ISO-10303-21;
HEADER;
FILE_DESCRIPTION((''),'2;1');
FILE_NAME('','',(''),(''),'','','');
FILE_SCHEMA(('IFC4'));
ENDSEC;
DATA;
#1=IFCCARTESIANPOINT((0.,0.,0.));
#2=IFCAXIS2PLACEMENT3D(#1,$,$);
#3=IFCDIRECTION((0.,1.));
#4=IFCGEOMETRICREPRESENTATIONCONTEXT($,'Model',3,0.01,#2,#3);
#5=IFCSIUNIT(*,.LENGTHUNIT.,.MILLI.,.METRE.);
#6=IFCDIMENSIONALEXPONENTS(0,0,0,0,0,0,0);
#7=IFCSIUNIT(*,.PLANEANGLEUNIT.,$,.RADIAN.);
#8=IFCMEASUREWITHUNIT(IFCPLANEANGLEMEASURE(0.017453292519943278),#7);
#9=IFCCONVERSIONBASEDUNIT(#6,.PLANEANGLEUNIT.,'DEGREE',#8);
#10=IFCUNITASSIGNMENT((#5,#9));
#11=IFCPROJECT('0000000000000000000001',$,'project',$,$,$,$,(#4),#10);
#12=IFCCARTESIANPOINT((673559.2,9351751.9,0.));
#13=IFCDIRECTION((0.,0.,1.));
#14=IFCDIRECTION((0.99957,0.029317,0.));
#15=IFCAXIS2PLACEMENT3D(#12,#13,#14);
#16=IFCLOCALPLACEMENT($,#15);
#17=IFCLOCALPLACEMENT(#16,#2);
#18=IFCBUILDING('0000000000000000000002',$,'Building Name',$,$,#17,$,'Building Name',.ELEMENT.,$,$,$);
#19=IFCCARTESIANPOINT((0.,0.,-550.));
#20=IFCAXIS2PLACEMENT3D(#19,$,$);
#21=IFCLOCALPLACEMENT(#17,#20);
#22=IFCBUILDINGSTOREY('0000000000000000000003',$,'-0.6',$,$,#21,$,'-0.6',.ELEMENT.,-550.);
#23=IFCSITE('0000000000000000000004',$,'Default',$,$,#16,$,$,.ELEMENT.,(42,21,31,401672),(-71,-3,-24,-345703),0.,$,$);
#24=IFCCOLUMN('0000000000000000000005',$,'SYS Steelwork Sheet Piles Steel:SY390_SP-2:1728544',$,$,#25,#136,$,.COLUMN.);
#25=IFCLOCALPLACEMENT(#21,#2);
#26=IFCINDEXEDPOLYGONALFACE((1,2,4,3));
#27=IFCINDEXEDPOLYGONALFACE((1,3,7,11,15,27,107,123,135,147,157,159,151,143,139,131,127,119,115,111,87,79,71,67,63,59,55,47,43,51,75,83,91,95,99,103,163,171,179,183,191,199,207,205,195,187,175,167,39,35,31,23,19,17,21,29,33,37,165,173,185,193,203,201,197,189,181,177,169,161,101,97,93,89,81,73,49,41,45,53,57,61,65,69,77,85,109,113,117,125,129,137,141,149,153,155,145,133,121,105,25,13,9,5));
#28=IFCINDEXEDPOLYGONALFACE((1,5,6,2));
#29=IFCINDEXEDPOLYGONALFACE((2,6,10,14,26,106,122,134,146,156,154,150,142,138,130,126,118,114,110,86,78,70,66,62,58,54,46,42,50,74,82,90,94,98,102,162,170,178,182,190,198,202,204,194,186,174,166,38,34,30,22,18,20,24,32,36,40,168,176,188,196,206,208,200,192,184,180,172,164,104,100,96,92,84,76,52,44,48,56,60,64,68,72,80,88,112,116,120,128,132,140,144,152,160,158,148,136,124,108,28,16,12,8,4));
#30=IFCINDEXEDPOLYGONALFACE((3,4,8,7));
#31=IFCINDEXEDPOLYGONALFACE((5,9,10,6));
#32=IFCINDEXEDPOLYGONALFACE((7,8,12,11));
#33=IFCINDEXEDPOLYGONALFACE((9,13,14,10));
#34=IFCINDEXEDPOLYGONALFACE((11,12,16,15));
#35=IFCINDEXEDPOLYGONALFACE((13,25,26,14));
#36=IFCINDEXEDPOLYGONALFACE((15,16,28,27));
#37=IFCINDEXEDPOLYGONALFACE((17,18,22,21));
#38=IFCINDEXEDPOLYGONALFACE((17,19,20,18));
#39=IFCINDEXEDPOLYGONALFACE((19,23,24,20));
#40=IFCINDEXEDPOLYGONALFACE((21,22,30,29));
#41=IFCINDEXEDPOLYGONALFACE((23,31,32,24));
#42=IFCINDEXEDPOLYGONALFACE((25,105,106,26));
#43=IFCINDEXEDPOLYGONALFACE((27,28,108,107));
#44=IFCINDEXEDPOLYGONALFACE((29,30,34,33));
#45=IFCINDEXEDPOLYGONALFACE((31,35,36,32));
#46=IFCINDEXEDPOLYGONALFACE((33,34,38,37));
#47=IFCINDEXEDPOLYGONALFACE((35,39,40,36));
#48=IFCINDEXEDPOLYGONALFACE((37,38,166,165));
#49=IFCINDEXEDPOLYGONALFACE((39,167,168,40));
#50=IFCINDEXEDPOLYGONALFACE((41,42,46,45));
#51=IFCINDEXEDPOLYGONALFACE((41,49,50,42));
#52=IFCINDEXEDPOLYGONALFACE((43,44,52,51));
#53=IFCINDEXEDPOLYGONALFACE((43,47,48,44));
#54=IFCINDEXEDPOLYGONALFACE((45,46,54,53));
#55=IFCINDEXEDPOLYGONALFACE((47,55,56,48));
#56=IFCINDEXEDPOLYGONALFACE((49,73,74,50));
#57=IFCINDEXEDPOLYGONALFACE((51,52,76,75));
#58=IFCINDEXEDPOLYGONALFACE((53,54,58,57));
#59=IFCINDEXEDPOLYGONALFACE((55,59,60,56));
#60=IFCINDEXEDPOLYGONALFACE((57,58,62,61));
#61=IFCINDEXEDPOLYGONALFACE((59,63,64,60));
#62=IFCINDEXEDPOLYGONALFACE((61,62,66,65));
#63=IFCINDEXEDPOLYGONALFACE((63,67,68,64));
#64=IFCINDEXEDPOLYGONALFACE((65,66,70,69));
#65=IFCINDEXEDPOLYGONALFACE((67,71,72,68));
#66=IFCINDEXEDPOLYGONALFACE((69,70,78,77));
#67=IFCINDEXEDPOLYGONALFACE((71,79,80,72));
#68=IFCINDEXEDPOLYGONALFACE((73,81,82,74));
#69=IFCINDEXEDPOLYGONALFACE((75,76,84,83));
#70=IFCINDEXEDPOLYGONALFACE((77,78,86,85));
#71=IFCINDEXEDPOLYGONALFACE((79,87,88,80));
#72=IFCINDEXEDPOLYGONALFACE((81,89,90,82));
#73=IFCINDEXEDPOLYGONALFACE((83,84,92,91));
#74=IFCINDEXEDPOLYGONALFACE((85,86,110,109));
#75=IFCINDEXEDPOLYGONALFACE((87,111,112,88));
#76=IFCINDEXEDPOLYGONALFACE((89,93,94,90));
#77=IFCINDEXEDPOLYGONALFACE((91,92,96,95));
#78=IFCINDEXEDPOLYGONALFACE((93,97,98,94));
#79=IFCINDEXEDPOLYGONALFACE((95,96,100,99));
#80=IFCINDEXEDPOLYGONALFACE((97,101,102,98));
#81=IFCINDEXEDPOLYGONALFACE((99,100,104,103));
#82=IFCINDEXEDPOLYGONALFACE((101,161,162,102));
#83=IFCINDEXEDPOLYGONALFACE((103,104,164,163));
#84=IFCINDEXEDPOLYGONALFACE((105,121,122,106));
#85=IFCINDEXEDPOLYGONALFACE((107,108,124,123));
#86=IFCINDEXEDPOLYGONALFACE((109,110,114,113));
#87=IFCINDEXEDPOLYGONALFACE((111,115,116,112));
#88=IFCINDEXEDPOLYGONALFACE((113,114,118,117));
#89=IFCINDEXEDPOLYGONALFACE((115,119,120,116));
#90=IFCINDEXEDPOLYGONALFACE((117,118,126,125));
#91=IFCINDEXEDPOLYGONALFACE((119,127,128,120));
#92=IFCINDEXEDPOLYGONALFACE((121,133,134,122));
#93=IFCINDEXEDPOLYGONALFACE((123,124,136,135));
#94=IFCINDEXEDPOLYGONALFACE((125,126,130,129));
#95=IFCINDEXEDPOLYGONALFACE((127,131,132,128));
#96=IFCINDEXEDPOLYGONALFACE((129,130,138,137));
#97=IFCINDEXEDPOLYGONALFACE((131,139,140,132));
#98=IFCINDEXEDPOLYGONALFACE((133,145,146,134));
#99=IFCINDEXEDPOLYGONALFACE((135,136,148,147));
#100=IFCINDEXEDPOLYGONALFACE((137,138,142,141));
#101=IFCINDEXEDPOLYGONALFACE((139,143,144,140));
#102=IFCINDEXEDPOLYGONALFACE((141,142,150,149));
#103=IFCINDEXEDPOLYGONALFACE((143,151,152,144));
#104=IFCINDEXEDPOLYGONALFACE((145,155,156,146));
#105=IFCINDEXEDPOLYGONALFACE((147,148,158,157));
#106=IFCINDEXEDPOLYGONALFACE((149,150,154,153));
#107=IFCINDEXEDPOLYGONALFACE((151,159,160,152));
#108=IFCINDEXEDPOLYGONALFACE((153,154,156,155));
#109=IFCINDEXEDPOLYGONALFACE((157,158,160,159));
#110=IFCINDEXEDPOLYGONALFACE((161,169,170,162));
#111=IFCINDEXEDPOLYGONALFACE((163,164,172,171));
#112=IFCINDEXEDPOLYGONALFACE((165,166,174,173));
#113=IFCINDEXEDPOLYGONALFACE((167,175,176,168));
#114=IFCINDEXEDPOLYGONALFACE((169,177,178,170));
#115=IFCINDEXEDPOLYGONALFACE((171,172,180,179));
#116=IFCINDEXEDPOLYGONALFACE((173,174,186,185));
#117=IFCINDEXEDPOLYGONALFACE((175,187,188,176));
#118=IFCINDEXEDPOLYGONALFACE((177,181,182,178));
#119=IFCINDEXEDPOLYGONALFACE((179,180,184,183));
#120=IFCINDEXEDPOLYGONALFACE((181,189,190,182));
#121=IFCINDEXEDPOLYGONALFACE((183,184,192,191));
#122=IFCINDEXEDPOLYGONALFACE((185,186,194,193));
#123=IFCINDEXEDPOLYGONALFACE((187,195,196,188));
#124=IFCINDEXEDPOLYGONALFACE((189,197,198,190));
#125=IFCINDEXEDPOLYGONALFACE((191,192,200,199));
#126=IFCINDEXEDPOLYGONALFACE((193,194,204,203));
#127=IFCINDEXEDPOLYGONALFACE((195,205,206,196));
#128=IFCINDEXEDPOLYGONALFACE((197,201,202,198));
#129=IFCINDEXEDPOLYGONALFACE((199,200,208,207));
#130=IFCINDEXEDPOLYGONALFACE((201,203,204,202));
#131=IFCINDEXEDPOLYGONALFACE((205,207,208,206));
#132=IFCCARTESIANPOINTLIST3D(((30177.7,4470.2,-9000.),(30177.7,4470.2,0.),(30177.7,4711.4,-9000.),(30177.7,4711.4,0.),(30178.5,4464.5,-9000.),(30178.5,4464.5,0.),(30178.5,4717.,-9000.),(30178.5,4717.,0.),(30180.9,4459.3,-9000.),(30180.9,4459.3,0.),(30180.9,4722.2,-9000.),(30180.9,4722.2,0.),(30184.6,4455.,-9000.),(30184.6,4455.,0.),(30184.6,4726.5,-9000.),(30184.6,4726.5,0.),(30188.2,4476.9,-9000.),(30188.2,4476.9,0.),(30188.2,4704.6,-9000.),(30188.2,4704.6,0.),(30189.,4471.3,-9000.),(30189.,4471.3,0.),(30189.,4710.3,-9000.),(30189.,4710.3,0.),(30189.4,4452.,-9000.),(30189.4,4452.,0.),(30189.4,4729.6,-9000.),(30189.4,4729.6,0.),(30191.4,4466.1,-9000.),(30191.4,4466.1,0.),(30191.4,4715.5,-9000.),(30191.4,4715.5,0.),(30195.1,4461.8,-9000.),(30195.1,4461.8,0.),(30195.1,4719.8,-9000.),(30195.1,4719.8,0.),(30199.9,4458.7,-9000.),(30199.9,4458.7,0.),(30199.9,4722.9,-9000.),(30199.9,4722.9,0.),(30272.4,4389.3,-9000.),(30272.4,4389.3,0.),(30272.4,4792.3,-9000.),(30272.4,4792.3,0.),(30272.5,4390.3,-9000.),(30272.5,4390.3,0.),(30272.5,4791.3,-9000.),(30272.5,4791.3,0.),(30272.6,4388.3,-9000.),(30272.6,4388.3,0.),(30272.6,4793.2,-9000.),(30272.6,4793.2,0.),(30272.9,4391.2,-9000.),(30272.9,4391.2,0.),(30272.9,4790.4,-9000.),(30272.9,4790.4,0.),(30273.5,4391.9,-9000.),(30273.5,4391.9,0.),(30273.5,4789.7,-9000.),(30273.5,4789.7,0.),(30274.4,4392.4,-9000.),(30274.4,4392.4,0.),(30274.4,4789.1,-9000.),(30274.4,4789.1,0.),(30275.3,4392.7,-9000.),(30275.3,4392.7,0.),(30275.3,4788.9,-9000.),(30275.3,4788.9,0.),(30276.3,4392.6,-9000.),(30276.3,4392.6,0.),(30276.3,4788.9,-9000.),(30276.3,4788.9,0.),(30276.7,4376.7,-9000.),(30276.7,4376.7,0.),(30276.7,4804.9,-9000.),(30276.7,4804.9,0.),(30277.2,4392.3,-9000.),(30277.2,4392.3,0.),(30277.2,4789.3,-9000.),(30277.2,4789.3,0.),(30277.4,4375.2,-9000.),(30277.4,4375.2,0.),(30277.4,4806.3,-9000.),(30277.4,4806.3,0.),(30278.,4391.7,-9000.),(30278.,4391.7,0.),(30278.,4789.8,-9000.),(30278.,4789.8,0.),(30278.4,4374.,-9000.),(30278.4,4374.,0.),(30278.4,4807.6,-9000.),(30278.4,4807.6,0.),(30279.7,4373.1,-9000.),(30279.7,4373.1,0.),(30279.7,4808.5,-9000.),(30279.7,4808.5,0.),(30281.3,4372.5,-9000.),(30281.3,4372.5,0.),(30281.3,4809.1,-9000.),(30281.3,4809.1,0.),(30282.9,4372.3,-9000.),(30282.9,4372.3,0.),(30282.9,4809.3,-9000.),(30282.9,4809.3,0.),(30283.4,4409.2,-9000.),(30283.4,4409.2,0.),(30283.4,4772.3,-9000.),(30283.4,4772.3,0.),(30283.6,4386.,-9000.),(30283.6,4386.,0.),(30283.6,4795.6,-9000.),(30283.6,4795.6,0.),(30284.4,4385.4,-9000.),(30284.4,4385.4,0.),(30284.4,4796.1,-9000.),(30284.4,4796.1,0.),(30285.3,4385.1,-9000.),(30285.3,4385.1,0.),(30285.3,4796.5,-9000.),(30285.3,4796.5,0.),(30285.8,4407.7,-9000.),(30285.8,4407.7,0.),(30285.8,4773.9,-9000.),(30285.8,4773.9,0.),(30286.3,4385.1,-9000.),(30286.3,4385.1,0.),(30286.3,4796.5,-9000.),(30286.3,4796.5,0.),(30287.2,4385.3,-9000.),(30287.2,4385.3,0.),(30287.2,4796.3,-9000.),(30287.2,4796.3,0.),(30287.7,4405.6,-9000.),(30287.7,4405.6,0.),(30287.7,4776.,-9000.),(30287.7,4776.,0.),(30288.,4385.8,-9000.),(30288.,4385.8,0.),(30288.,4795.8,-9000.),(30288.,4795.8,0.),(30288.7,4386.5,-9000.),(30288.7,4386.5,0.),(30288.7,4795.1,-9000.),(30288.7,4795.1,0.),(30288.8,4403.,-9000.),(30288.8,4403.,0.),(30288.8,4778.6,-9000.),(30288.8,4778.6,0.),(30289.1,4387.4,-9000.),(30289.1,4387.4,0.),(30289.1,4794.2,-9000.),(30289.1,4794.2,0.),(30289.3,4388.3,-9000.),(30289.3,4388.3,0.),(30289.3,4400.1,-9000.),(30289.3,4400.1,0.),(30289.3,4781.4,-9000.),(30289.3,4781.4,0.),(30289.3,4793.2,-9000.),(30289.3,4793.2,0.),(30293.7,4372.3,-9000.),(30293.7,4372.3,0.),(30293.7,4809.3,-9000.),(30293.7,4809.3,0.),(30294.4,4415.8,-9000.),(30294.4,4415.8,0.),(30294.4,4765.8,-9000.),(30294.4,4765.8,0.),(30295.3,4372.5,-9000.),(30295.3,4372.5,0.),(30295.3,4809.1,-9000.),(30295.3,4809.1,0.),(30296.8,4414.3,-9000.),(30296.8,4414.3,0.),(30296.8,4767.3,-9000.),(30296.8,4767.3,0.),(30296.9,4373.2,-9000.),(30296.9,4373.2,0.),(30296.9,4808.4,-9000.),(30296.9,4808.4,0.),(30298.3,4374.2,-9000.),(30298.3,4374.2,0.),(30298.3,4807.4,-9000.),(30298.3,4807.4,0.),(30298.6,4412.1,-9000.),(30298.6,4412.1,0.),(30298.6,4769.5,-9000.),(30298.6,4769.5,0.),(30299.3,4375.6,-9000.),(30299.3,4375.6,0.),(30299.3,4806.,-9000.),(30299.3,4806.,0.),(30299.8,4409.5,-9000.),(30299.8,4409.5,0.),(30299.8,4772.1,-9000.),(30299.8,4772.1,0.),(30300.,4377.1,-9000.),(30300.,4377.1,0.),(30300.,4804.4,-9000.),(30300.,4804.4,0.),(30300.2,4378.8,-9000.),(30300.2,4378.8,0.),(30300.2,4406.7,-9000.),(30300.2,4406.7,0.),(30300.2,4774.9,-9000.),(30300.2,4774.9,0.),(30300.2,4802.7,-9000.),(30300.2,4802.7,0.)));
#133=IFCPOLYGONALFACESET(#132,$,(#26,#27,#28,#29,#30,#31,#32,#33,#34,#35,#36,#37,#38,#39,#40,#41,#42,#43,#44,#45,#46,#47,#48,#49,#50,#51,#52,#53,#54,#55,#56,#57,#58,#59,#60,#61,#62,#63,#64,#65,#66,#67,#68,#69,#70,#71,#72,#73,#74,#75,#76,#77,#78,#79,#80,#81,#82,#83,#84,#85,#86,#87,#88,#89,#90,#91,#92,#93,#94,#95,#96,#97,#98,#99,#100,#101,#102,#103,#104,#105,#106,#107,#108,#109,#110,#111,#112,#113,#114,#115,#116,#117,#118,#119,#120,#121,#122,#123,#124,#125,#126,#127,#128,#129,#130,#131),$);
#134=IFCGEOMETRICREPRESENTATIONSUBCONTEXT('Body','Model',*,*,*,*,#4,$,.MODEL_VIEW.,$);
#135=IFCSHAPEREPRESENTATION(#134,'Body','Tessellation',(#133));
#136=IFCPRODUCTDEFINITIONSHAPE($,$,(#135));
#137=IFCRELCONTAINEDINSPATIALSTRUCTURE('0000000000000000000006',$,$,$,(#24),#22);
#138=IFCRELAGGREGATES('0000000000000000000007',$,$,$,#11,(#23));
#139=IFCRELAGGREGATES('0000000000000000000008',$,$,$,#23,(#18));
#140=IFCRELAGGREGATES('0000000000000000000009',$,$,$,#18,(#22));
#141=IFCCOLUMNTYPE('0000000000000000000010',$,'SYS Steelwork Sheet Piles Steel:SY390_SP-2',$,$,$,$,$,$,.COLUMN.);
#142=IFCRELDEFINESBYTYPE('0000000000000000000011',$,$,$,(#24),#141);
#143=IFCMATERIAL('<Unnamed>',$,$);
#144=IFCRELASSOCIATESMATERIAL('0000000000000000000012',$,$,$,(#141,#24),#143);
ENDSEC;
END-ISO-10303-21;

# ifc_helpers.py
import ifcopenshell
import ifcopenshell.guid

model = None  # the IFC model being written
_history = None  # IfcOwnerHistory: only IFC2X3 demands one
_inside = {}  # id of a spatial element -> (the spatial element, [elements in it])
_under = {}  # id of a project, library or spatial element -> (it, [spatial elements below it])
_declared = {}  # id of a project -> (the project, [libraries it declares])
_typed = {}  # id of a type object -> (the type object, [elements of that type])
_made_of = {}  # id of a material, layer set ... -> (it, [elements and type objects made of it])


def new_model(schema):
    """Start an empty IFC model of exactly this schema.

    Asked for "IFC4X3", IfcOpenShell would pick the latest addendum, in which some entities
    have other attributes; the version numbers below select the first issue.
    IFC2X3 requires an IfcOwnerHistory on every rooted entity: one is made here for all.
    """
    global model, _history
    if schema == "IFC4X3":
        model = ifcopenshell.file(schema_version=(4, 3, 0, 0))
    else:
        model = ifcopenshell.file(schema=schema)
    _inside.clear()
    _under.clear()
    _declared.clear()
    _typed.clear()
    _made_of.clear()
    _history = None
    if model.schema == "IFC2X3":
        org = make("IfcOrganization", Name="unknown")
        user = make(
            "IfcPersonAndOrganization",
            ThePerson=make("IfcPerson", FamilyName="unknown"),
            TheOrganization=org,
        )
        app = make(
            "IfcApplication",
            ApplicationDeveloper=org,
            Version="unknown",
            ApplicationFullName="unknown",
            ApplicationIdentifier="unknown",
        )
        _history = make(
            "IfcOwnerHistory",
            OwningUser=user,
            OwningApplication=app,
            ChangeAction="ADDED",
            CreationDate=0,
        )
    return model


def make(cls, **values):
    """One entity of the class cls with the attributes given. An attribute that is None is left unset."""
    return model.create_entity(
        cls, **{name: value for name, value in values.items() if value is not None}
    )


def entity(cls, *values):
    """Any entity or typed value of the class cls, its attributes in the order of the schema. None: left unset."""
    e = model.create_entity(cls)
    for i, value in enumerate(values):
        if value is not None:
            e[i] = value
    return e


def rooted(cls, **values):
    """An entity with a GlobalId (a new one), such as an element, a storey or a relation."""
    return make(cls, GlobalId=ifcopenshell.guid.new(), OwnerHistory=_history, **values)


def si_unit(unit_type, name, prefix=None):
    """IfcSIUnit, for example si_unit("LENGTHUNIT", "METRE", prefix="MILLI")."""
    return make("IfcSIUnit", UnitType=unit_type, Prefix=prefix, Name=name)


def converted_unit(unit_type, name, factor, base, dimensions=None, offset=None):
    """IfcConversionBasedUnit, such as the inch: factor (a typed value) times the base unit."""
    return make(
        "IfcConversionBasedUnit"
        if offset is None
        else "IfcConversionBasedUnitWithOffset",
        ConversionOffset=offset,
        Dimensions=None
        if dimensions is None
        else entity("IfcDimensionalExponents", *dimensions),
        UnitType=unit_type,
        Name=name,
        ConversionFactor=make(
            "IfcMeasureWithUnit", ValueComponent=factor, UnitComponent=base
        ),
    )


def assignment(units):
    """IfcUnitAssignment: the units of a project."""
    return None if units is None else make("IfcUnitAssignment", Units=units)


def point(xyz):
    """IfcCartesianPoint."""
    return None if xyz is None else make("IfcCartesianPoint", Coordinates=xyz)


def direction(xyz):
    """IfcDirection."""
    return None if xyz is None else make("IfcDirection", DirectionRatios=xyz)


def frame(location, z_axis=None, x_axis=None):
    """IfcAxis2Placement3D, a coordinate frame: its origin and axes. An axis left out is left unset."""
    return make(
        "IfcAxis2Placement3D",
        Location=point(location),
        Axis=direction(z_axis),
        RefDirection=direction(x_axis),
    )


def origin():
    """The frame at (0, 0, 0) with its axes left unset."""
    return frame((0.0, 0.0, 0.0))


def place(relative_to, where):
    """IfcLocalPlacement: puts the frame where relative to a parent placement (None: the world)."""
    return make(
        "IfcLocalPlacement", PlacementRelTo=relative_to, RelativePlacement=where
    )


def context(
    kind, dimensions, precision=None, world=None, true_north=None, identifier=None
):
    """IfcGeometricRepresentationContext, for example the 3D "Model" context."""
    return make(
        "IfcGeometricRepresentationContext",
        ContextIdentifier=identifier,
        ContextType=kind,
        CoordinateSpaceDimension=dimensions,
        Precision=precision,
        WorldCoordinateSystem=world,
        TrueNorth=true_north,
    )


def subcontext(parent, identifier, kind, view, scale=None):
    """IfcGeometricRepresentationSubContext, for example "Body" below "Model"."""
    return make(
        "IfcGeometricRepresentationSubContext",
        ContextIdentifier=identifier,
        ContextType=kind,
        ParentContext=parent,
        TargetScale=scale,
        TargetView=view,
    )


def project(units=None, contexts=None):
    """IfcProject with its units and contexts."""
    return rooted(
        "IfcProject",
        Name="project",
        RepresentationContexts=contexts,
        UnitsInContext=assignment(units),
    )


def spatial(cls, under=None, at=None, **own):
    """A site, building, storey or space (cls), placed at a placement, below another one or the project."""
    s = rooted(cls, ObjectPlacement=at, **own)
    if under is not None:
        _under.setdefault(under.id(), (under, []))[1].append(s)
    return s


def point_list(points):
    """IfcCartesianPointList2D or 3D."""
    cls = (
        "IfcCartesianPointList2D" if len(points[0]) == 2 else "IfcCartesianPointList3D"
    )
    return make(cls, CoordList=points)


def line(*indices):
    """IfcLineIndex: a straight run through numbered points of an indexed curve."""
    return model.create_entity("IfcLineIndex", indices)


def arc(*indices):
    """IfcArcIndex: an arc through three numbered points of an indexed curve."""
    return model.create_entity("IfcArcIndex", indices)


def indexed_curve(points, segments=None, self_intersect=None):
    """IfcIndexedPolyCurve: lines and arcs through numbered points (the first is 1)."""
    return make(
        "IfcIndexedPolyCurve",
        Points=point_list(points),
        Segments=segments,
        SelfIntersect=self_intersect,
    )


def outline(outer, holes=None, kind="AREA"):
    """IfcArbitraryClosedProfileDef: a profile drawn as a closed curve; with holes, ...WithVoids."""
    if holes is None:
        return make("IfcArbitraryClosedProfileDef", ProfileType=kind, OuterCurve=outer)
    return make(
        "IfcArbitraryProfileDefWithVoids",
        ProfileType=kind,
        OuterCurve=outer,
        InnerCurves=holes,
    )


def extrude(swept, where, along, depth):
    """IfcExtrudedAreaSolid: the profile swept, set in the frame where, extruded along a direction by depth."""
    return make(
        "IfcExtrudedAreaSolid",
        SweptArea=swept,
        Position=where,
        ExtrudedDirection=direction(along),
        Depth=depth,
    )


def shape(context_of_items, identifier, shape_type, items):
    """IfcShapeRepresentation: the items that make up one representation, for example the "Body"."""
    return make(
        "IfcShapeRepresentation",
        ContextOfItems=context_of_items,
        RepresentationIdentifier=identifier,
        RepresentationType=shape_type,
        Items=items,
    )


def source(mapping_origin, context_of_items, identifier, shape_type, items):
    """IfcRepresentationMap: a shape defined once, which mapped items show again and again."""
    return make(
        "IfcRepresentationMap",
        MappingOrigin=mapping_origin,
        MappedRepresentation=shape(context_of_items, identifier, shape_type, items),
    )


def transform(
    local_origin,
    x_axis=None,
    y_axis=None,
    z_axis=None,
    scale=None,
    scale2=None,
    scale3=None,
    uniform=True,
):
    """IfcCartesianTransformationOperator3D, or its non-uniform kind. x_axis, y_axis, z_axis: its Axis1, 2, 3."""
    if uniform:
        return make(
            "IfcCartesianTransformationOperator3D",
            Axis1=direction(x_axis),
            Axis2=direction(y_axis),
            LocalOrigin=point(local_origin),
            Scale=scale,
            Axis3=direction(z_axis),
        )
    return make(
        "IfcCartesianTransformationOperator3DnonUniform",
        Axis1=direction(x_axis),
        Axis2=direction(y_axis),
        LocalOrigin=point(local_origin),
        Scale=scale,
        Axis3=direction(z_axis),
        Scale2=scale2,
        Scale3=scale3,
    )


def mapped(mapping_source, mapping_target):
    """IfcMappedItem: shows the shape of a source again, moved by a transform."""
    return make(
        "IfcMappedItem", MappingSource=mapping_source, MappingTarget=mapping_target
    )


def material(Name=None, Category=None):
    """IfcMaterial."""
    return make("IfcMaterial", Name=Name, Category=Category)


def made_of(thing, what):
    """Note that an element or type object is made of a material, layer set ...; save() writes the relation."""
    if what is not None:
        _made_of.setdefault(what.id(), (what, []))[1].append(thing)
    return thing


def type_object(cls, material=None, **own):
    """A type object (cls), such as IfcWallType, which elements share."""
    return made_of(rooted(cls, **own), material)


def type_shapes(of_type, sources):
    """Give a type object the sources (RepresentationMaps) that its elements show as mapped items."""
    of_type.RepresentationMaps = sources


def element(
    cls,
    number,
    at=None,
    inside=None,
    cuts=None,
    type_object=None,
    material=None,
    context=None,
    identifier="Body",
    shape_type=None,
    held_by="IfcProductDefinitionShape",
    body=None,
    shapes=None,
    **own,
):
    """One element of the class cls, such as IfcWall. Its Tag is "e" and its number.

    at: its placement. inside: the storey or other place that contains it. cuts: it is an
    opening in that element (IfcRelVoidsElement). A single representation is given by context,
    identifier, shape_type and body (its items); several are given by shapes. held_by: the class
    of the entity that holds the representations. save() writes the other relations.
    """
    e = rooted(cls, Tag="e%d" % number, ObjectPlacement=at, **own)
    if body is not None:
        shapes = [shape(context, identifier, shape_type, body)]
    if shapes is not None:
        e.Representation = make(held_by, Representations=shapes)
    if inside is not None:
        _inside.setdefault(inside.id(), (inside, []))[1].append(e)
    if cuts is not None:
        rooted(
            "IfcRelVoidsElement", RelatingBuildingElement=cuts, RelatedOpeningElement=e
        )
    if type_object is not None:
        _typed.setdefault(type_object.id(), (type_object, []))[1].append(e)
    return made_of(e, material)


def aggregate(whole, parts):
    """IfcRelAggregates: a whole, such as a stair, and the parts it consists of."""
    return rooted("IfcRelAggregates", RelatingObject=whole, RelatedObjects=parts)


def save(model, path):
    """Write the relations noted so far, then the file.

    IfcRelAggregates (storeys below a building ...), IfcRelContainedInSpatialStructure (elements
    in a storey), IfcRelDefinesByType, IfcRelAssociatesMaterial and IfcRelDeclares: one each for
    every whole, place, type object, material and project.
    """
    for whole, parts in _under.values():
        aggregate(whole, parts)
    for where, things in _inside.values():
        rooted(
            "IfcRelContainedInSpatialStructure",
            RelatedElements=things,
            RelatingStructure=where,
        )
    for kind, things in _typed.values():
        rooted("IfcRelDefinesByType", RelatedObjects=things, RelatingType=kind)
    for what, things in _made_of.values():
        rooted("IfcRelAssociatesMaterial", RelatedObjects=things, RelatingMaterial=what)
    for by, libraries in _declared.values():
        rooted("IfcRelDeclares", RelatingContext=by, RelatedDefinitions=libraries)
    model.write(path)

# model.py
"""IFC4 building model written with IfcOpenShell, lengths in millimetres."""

from ifc_helpers import new_model, entity, si_unit, converted_unit, direction, frame, origin, place, context, subcontext, project, spatial, line, arc, indexed_curve, outline, extrude, source, transform, mapped, material, type_object, type_shapes, element, save


model = new_model("IFC4")

# Units and contexts
model_context = context("Model", 3, precision=0.01, world=origin(), true_north=direction((0.0, 1.0)))
body_context = subcontext(model_context, "Body", "Model", "MODEL_VIEW")
ifc_project = project(units=[si_unit("LENGTHUNIT", "METRE", prefix="MILLI"), converted_unit("PLANEANGLEUNIT", "DEGREE", entity("IfcPlaneAngleMeasure", 0.017453292519943278), si_unit("PLANEANGLEUNIT", "RADIAN"), dimensions=[0, 0, 0, 0, 0, 0, 0])], contexts=[model_context])

# Site, building, storey
site_placement = place(None, frame((673559.2, 9351751.9, 0.0), z_axis=(0.0, 0.0, 1.0), x_axis=(0.99957, 0.029317, 0.0)))
site = spatial("IfcSite", under=ifc_project, at=site_placement, Name="Default", CompositionType="ELEMENT", RefLatitude=(42, 21, 31, 401672), RefLongitude=(-71, -3, -24, -345703), RefElevation=0.0)
building_placement = place(site_placement, origin())
building = spatial("IfcBuilding", under=site, at=building_placement, Name="Building Name", LongName="Building Name", CompositionType="ELEMENT")
storey_placement = place(building_placement, frame((0.0, 0.0, -550.0)))
storey = spatial("IfcBuildingStorey", under=building, at=storey_placement, Name="-0.6", LongName="-0.6", CompositionType="ELEMENT", Elevation=-550.0)

# Column
ifc_material_1 = material(Name="<Unnamed>")
column_type = type_object("IfcColumnType", Name="SYS Steelwork Sheet Piles Steel:SY390_SP-2", PredefinedType="COLUMN", material=ifc_material_1)
shared_shape_1 = source(origin(), body_context, "Body", "SweptSolid", [
    extrude(outline(indexed_curve([(-120.6, 84.7), (-131.4, 81.6), (-138.8, 73.0), (-181.5, -20.9), (-185.2, -25.2), (-190.6, -26.8), (-202.5, -26.8), (-205.5, -24.8), (-204.8, -21.2), (-199.1, -15.5), (-198.6, -11.5), (-202.5, -10.1), (-214.1, -14.2), (-217.3, -16.6), (-218.5, -20.4), (-218.5, -31.2), (-216.6, -35.8), (-211.9, -37.8), (-184.1, -37.8), (-178.7, -36.2), (-175.0, -31.9), (-132.1, 62.5), (-124.7, 71.1), (-113.9, 74.2), (113.9, 74.2), (124.7, 71.1), (132.1, 62.5), (175.0, -31.9), (178.7, -36.2), (184.1, -37.8), (211.9, -37.8), (216.6, -35.8), (218.5, -31.2), (218.5, -20.4), (217.3, -16.6), (214.1, -14.2), (202.5, -10.1), (198.6, -11.5), (199.1, -15.5), (204.8, -21.2), (205.5, -24.8), (202.5, -26.8), (190.6, -26.8), (185.2, -25.2), (181.5, -20.9), (138.8, 73.0), (131.4, 81.6), (120.6, 84.7)], segments=[arc(1, 2, 3), line(3, 4), arc(4, 5, 6), line(6, 7), arc(7, 8, 9), line(9, 10), arc(10, 11, 12), line(12, 13), arc(13, 14, 15), line(15, 16), arc(16, 17, 18), line(18, 19), arc(19, 20, 21), line(21, 22), arc(22, 23, 24), line(24, 25), arc(25, 26, 27), line(27, 28), arc(28, 29, 30), line(30, 31), arc(31, 32, 33), line(33, 34), arc(34, 35, 36), line(36, 37), arc(37, 38, 39), line(39, 40), arc(40, 41, 42), line(42, 43), arc(43, 44, 45), line(45, 46), arc(46, 47, 48), line(48, 1)], self_intersect=False)), frame((0.0, 15.3, -9550.0)), (0.0, 0.0, 1.0), 9000.0),
])
type_shapes(column_type, [shared_shape_1])
for number, where, z_axis, x_axis, name in (
    (1, (30277.7, 4590.8, 550.0), (0.0, 0.0, 1.0), (0.0, 1.0, 0.0), "SYS Steelwork Sheet Piles Steel:SY390_SP-2:1728544"),
):
    element("IfcColumn", number, at=place(storey_placement, frame(where, z_axis=z_axis, x_axis=x_axis)), inside=storey, type_object=column_type, material=ifc_material_1, Name=name, PredefinedType="COLUMN", context=body_context, shape_type="MappedRepresentation", body=[
        mapped(shared_shape_1, transform((0.0, 0.0, 0.0), scale=1.0)),
    ])

save(model, "model.ifc")
